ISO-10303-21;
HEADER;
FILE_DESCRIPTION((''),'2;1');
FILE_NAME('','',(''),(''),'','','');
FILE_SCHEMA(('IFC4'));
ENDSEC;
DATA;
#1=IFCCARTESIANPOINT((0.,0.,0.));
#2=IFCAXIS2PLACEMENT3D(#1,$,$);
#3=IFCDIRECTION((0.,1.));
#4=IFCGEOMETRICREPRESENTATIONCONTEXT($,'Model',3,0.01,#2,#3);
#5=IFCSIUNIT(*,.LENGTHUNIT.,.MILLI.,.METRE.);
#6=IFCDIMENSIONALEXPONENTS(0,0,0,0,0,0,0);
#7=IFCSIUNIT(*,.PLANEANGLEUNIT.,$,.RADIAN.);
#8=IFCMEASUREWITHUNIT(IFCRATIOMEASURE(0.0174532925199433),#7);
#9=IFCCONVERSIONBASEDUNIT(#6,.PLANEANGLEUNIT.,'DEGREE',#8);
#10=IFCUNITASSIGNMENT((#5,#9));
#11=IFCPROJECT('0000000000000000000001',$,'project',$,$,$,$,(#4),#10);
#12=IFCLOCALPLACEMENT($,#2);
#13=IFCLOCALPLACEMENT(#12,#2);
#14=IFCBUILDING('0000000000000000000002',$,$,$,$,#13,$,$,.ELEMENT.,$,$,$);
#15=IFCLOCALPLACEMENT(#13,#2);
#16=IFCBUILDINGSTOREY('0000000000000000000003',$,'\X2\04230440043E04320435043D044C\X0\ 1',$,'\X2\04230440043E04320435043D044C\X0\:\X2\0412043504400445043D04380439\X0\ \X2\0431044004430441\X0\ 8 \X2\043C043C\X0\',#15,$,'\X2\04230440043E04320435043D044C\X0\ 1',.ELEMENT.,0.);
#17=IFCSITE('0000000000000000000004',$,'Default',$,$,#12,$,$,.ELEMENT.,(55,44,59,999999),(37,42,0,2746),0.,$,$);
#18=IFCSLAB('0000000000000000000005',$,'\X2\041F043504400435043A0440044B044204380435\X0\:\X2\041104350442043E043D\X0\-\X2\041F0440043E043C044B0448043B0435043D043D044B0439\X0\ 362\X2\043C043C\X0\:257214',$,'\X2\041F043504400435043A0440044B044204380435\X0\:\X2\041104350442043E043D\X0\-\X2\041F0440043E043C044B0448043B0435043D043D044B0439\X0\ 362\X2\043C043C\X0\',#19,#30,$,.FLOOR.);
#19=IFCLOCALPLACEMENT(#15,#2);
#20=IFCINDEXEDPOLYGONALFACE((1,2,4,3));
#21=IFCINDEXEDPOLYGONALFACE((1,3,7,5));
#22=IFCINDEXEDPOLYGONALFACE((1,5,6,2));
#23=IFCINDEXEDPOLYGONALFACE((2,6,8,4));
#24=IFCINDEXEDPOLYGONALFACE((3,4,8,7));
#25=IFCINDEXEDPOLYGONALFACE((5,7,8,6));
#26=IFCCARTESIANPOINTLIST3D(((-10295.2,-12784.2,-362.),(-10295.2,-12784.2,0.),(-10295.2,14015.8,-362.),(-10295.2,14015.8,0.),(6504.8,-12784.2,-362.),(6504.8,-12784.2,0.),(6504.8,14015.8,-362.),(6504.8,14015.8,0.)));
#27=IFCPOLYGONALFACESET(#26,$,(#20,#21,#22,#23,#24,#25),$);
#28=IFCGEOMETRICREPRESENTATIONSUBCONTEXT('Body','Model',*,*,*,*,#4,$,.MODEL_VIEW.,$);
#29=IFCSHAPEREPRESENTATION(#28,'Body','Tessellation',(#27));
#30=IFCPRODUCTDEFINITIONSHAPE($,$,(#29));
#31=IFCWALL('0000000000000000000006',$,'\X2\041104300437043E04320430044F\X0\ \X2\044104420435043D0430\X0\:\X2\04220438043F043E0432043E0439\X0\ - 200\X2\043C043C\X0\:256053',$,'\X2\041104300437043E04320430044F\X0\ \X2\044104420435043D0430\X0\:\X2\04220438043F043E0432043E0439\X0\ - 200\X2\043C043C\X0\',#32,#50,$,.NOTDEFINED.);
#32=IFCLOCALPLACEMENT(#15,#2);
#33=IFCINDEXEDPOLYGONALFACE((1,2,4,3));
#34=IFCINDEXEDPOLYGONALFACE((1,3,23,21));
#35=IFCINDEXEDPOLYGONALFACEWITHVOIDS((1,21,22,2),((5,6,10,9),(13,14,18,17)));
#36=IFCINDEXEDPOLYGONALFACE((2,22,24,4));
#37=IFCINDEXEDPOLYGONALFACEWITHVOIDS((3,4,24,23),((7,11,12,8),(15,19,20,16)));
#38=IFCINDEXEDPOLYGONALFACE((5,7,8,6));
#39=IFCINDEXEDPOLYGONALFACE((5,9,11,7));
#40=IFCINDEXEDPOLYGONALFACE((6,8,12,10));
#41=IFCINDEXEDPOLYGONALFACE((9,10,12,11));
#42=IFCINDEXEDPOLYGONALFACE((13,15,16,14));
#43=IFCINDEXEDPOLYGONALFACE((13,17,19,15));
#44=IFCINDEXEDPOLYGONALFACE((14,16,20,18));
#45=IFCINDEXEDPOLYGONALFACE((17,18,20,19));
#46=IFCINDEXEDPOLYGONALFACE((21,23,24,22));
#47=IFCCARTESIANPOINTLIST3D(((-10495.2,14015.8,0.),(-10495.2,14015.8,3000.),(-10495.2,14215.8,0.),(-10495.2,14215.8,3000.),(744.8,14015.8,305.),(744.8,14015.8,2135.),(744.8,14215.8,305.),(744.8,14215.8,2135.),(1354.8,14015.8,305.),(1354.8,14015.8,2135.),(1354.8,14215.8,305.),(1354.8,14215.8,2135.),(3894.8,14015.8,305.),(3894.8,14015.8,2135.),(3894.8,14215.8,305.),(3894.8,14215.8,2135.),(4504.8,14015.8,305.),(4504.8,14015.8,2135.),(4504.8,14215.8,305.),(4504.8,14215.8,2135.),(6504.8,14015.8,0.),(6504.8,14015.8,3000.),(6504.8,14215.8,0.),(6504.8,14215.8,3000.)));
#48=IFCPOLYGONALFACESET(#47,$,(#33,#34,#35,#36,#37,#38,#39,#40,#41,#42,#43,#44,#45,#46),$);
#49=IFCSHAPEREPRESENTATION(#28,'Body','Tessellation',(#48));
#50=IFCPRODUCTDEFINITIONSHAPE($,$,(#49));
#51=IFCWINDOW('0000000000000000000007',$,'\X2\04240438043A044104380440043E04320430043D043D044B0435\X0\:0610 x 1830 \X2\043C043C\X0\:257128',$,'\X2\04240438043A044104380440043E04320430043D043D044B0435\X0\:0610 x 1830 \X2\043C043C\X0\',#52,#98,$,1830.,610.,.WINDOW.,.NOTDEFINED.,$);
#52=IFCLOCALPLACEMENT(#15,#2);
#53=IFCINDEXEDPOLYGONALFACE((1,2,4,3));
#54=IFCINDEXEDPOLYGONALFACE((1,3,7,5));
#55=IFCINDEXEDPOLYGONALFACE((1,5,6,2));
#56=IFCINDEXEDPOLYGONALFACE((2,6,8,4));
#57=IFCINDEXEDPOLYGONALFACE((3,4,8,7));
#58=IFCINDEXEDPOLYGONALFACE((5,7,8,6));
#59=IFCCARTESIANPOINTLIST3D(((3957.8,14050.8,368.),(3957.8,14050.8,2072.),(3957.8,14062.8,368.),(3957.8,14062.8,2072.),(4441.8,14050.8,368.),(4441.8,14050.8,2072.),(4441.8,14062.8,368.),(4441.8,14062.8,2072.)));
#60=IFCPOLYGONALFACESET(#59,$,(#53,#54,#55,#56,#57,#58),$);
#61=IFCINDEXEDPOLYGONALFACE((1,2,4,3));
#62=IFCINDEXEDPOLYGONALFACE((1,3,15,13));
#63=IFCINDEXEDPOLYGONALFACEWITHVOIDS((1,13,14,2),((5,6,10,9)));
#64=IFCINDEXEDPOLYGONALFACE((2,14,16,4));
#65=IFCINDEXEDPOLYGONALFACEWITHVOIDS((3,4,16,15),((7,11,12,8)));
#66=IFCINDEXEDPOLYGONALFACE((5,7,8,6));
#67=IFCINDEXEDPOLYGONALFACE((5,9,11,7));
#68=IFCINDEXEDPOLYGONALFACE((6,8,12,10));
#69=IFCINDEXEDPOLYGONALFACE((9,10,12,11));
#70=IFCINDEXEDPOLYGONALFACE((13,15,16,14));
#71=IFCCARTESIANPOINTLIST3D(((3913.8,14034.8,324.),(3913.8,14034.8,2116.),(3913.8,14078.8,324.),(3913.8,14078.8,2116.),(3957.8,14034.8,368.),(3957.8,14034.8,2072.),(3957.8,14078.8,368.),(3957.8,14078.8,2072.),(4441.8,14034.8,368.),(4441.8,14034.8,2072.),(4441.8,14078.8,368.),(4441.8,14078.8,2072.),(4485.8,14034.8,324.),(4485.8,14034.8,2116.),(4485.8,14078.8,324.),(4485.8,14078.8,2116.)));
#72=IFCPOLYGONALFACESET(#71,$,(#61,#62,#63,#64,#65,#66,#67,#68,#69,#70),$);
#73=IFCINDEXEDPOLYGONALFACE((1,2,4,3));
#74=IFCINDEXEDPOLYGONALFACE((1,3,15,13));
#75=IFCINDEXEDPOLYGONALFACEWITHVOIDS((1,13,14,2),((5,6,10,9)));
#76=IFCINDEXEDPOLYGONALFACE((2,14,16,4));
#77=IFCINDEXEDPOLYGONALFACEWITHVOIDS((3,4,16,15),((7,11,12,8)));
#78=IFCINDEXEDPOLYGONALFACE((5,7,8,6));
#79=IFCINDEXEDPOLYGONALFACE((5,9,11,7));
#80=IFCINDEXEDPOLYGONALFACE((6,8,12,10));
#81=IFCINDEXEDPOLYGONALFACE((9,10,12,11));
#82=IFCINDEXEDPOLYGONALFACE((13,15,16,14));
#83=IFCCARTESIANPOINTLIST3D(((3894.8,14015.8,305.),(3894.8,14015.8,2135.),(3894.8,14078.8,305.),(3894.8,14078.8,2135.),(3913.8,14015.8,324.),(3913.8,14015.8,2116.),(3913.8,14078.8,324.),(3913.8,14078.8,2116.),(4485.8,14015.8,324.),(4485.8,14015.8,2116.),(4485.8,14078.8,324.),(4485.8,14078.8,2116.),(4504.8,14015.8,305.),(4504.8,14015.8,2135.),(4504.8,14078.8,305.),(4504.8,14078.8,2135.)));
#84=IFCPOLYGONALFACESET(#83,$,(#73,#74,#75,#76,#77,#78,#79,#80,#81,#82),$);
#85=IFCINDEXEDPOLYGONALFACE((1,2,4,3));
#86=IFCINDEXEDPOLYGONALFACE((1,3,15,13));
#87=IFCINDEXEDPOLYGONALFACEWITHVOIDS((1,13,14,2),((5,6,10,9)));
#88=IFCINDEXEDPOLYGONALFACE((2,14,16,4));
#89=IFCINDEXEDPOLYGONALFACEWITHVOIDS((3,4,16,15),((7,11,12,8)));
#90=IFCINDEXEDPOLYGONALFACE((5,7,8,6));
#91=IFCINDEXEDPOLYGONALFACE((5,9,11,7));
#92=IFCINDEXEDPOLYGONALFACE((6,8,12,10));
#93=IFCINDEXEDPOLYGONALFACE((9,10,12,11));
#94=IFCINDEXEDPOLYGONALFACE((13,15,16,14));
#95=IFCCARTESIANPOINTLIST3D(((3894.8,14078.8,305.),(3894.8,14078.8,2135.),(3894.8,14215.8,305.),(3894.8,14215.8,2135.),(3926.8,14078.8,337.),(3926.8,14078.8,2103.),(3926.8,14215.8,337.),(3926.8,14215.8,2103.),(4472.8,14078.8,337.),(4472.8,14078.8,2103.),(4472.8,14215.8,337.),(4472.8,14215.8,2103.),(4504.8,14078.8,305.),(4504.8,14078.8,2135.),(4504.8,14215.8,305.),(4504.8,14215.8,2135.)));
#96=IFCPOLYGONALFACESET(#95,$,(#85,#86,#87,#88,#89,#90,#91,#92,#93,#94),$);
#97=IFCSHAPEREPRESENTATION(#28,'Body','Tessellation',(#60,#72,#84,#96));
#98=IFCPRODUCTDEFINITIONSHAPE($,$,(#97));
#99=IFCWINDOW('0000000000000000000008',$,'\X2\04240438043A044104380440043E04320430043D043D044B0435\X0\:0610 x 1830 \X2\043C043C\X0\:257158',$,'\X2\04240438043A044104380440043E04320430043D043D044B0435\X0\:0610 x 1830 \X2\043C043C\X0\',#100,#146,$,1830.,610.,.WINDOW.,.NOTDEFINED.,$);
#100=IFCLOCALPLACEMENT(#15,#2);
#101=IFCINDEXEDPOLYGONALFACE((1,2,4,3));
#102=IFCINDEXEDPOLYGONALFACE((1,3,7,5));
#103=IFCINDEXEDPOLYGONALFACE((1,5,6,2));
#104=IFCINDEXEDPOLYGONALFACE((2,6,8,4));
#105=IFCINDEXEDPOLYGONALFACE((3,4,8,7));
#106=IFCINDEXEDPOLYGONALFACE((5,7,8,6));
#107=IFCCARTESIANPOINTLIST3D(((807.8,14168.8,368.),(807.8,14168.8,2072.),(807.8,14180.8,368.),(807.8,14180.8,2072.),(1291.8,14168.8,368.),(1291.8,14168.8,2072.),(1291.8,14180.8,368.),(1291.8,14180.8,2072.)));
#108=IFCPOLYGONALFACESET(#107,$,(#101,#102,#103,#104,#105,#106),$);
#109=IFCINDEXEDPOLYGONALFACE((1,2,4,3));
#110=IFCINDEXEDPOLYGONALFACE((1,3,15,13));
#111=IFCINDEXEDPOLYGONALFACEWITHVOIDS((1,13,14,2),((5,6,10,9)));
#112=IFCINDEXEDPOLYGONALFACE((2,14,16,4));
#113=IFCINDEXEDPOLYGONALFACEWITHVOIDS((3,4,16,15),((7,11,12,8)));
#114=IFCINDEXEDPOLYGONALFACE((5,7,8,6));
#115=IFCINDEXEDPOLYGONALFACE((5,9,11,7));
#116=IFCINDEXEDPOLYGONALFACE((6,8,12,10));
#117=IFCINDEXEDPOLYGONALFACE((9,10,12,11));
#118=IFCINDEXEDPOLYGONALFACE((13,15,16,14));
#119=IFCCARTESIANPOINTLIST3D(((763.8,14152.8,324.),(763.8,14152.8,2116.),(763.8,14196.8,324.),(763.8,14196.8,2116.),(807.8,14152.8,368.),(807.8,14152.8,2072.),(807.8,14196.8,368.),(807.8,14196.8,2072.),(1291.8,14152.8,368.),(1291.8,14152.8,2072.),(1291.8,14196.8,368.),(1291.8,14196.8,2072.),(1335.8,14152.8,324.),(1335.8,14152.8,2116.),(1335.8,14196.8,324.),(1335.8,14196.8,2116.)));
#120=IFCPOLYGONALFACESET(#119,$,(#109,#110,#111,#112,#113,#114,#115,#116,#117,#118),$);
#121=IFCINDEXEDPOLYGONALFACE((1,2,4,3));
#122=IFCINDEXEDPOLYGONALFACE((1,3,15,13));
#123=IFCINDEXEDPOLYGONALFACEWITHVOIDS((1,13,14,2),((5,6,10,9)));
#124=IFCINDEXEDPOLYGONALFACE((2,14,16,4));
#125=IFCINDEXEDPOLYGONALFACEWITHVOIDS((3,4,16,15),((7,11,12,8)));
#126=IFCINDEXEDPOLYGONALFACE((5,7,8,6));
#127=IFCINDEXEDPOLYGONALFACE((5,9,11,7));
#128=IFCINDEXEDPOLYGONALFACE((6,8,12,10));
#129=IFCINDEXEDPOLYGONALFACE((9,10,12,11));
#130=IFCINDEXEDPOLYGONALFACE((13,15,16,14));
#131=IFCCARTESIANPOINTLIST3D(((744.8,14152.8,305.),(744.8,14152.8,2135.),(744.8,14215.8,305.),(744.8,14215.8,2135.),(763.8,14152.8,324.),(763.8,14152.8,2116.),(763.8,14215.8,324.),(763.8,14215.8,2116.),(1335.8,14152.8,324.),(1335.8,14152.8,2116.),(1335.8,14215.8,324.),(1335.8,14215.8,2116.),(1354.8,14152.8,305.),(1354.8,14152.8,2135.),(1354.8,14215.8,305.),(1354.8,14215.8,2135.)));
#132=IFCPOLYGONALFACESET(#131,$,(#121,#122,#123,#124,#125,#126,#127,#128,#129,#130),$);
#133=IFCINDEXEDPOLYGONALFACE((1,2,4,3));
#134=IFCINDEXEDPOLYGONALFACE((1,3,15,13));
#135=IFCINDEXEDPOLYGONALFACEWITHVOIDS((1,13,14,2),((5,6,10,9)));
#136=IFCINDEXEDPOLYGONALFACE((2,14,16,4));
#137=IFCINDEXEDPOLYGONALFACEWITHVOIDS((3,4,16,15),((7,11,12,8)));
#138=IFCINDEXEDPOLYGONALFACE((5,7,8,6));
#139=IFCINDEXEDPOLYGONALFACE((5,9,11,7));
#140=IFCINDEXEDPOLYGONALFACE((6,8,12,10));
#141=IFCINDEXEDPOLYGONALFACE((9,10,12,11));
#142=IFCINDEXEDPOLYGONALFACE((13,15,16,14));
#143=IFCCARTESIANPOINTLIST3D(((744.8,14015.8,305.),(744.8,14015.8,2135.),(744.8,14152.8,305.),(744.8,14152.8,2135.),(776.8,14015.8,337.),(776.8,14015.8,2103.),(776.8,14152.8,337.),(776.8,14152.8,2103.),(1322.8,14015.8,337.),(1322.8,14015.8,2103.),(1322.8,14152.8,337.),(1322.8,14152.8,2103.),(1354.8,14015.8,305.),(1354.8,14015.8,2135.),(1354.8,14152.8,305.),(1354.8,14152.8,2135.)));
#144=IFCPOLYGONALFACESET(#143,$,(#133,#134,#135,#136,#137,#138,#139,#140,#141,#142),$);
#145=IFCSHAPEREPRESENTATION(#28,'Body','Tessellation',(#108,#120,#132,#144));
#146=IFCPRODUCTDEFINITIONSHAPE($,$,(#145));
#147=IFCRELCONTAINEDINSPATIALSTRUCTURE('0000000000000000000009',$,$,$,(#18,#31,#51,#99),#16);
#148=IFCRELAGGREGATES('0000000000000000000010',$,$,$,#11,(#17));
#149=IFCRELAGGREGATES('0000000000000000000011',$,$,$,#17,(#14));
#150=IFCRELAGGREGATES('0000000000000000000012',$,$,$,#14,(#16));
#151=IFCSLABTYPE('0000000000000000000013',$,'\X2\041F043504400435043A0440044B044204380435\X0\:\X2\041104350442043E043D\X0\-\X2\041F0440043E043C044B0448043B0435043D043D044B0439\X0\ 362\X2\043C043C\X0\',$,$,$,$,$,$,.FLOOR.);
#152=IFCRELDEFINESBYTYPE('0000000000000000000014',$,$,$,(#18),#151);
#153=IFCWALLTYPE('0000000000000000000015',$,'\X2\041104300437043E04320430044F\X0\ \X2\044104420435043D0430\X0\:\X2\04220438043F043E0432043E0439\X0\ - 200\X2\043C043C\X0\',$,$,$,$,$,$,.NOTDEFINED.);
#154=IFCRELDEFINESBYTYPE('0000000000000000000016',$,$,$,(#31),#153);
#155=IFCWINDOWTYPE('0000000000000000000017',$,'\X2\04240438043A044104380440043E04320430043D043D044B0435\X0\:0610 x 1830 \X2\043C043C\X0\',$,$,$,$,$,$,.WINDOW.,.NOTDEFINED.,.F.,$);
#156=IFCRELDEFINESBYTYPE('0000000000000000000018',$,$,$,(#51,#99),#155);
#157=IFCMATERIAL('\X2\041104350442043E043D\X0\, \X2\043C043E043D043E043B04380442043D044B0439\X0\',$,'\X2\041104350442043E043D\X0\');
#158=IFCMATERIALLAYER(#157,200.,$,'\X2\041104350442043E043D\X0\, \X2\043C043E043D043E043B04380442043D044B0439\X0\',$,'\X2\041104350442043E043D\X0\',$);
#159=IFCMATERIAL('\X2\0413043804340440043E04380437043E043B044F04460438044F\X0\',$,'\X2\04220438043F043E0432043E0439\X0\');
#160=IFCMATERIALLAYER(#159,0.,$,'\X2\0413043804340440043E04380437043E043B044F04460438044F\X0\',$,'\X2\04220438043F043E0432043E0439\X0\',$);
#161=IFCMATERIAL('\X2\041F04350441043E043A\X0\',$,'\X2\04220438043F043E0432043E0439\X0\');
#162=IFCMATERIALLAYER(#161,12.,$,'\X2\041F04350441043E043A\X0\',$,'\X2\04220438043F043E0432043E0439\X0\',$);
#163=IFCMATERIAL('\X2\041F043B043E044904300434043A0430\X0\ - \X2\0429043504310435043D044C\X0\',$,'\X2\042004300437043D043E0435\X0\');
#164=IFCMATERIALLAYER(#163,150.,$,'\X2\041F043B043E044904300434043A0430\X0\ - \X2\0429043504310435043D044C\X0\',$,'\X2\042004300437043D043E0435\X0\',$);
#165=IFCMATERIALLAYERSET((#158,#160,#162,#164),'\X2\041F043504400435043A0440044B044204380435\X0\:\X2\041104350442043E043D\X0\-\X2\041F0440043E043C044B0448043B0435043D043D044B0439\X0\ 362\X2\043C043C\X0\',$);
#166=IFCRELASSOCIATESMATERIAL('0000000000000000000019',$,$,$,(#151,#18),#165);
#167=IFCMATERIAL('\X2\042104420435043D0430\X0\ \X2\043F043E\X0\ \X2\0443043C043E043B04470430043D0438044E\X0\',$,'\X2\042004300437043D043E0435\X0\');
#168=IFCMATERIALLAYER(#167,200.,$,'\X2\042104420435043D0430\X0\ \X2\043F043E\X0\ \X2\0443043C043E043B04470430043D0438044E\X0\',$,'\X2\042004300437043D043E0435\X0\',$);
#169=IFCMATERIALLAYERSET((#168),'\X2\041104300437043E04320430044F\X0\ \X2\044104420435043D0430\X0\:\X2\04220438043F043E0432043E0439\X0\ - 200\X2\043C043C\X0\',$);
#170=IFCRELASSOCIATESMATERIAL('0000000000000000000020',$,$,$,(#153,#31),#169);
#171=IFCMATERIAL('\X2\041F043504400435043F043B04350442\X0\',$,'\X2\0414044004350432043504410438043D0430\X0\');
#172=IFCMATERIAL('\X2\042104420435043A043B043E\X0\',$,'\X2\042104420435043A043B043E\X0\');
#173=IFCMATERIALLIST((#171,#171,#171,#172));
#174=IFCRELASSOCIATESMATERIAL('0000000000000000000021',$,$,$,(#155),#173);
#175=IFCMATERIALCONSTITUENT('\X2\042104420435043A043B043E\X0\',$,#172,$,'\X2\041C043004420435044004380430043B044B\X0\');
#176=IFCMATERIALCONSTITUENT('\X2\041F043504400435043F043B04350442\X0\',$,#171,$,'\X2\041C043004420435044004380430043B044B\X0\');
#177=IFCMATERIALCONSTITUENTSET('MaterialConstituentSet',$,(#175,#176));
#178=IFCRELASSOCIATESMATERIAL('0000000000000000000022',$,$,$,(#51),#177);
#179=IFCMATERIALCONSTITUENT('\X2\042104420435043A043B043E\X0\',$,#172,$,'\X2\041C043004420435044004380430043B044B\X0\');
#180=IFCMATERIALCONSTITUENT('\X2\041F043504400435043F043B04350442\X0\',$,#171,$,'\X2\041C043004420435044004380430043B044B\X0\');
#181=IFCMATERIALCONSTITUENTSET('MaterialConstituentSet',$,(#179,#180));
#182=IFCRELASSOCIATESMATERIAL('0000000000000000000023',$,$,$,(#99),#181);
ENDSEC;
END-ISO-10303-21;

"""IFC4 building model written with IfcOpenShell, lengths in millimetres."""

from ifc_helpers import new_model, entity, si_unit, converted_unit, direction, frame, frame_2d, origin, place, context, subcontext, project, spatial, polyline, rectangle, outline, extrude, source, transform, mapped, material, material_list, layer, layer_set, layer_usage, constituent, constituent_set, type_object, type_shapes, element, fill, save


model = new_model("IFC4")

# Units and contexts
model_context = context("Model", 3, precision=0.01, world=origin(), true_north=direction((0.0, 1.0)))
body_context = subcontext(model_context, "Body", "Model", "MODEL_VIEW")
ifc_project = project(units=[si_unit("LENGTHUNIT", "METRE", prefix="MILLI"), converted_unit("PLANEANGLEUNIT", "DEGREE", entity("IfcRatioMeasure", 0.0174532925199433), si_unit("PLANEANGLEUNIT", "RADIAN"), dimensions=[0, 0, 0, 0, 0, 0, 0])], contexts=[model_context])

# Site, building, storey
site_placement = place(None, origin())
site = spatial("IfcSite", under=ifc_project, at=site_placement, Name="Default", CompositionType="ELEMENT", RefLatitude=(55, 44, 59, 999999), RefLongitude=(37, 42, 0, 2746), RefElevation=0.0)
building_placement = place(site_placement, origin())
building = spatial("IfcBuilding", under=site, at=building_placement, CompositionType="ELEMENT")
storey_placement = place(building_placement, origin())
storey = spatial("IfcBuildingStorey", under=building, at=storey_placement, Name="Уровень 1", ObjectType="Уровень:Верхний брус 8 мм", LongName="Уровень 1", CompositionType="ELEMENT", Elevation=0.0)

# Slab
ifc_material_1 = material(Name="Бетон, монолитный", Category="Бетон")
ifc_layer_1 = layer(ifc_material_1, 200.0, Name="Бетон, монолитный", Category="Бетон")
ifc_material_2 = material(Name="Гидроизоляция", Category="Типовой")
ifc_layer_2 = layer(ifc_material_2, 0.0, Name="Гидроизоляция", Category="Типовой")
ifc_material_3 = material(Name="Песок", Category="Типовой")
ifc_layer_3 = layer(ifc_material_3, 12.0, Name="Песок", Category="Типовой")
ifc_material_4 = material(Name="Площадка - Щебень", Category="Разное")
ifc_layer_4 = layer(ifc_material_4, 150.0, Name="Площадка - Щебень", Category="Разное")
ifc_layer_set_1 = layer_set([ifc_layer_1, ifc_layer_2, ifc_layer_3, ifc_layer_4], Name="Перекрытие:Бетон-Промышленный 362мм")
ifc_layer_usage_1 = layer_usage(ifc_layer_set_1, "AXIS3", "POSITIVE", 0.0)
slab_type = type_object("IfcSlabType", Name="Перекрытие:Бетон-Промышленный 362мм", PredefinedType="FLOOR", material=ifc_layer_set_1)
slab_placement = place(storey_placement, origin())
element("IfcSlab", 1, at=slab_placement, inside=storey, type_object=slab_type, material=ifc_layer_usage_1, Name="Перекрытие:Бетон-Промышленный 362мм:257214", ObjectType="Перекрытие:Бетон-Промышленный 362мм", PredefinedType="FLOOR", context=body_context, shape_type="SweptSolid", body=[
    extrude(rectangle(XDim=26800.0, YDim=16800.0, at=frame_2d((0.0, 0.0), x_axis=(1.0, 0.0))), frame((-1895.2, 615.8, 0.0), z_axis=(0.0, 0.0, -1.0), x_axis=(0.0, 1.0, 0.0)), (0.0, 0.0, 1.0), 362.0),
])

# Wall, openings, windows
ifc_material_5 = material(Name="Стена по умолчанию", Category="Разное")
ifc_layer_5 = layer(ifc_material_5, 200.0, Name="Стена по умолчанию", Category="Разное")
ifc_layer_set_2 = layer_set([ifc_layer_5], Name="Базовая стена:Типовой - 200мм")
ifc_layer_usage_2 = layer_usage(ifc_layer_set_2, "AXIS2", "NEGATIVE", 100.0)
wall_type = type_object("IfcWallType", Name="Базовая стена:Типовой - 200мм", PredefinedType="NOTDEFINED", material=ifc_layer_set_2)
wall_1_placement = place(storey_placement, frame((-10495.2, 14115.8, 0.0)))
wall_1 = element("IfcWall", 2, at=wall_1_placement, inside=storey, type_object=wall_type, material=ifc_layer_usage_2, Name="Базовая стена:Типовой - 200мм:256053", ObjectType="Базовая стена:Типовой - 200мм", PredefinedType="NOTDEFINED", context=body_context, shape_type="SweptSolid", body=[
    extrude(rectangle(XDim=17000.0, YDim=200.0, at=frame_2d((8500.0, 0.0), x_axis=(-1.0, 0.0))), origin(), (0.0, 0.0, 1.0), 3000.0),
])
opening_1_placement = place(wall_1_placement, frame((15000.0, 100.0, 305.0)))
opening_1 = element("IfcOpeningElement", 3, at=opening_1_placement, cuts=wall_1, ObjectType="Opening", PredefinedType="OPENING", context=body_context, shape_type="SweptSolid", body=[
    extrude(rectangle(XDim=1830.0, YDim=610.0, at=frame_2d((915.0, 305.0), x_axis=(1.0, 0.0))), frame((0.0, 0.0, 0.0), z_axis=(0.0, -1.0, 0.0), x_axis=(0.0, 0.0, 1.0)), (0.0, 0.0, 1.0), 200.0),
])
opening_2_placement = place(wall_1_placement, frame((11240.0, -100.0, 305.0)))
opening_2 = element("IfcOpeningElement", 4, at=opening_2_placement, cuts=wall_1, ObjectType="Opening", PredefinedType="OPENING", context=body_context, shape_type="SweptSolid", body=[
    extrude(rectangle(XDim=1830.0, YDim=610.0, at=frame_2d((915.0, 305.0), x_axis=(1.0, 0.0))), frame((0.0, 0.0, 0.0), z_axis=(0.0, 1.0, 0.0), x_axis=(0.0, 0.0, 1.0)), (0.0, 0.0, 1.0), 200.0),
])
ifc_material_6 = material(Name="Стекло", Category="Стекло")
ifc_constituent_1 = constituent(ifc_material_6, Name="Стекло", Category="Материалы")
ifc_material_7 = material(Name="Переплет", Category="Древесина")
ifc_constituent_2 = constituent(ifc_material_7, Name="Переплет", Category="Материалы")
ifc_constituent_set_1 = constituent_set(constituents=[ifc_constituent_1, ifc_constituent_2], Name="MaterialConstituentSet")
ifc_material_list_1 = material_list([ifc_material_7, ifc_material_7, ifc_material_7, ifc_material_6])
window_type = type_object("IfcWindowType", Name="Фиксированные:0610 x 1830 мм", ParameterTakesPrecedence=False, PartitioningType="NOTDEFINED", PredefinedType="WINDOW", material=ifc_material_list_1)
shared_shape_1 = source(origin(), body_context, "Body", "SweptSolid", [
    extrude(rectangle(XDim=12.0, YDim=484.0, at=frame_2d((0.0, 0.0), x_axis=(1.0, 0.0))), frame((305.0, 159.0, 63.0), z_axis=(0.0, 0.0, 1.0), x_axis=(0.0, -1.0, 0.0)), (0.0, 0.0, 1.0), 1704.0),
    extrude(outline(polyline([(-286.0, -896.0), (286.0, -896.0), (286.0, 896.0), (-286.0, 896.0), (-286.0, -896.0)]), holes=[polyline([(-242.0, -852.0), (-242.0, 852.0), (242.0, 852.0), (242.0, -852.0), (-242.0, -852.0)])]), frame((305.0, 137.0, 915.0), z_axis=(0.0, 1.0, 0.0), x_axis=(1.0, 0.0, 0.0)), (0.0, 0.0, 1.0), 44.0),
    extrude(outline(polyline([(-305.0, -915.0), (305.0, -915.0), (305.0, 915.0), (-305.0, 915.0), (-305.0, -915.0)]), holes=[polyline([(-286.0, -896.0), (-286.0, 896.0), (286.0, 896.0), (286.0, -896.0), (-286.0, -896.0)])]), frame((305.0, 137.0, 915.0), z_axis=(0.0, 1.0, 0.0), x_axis=(1.0, 0.0, 0.0)), (0.0, 0.0, 1.0), 63.0),
    extrude(outline(polyline([(-305.0, -915.0), (305.0, -915.0), (305.0, 915.0), (-305.0, 915.0), (-305.0, -915.0)]), holes=[polyline([(-273.0, -883.0), (-273.0, 883.0), (273.0, 883.0), (273.0, -883.0), (-273.0, -883.0)])]), frame((305.0, 0.0, 915.0), z_axis=(0.0, 1.0, 0.0), x_axis=(1.0, 0.0, 0.0)), (0.0, 0.0, 1.0), 137.0),
])
type_shapes(window_type, [shared_shape_1])
window_1_placement = place(opening_1_placement, frame((0.0, 0.0, 0.0), z_axis=(0.0, 0.0, 1.0), x_axis=(-1.0, 0.0, 0.0)))
window_1 = element("IfcWindow", 5, at=window_1_placement, inside=storey, type_object=window_type, material=ifc_constituent_set_1, Name="Фиксированные:0610 x 1830 мм:257128", ObjectType="Фиксированные:0610 x 1830 мм", OverallHeight=1830.0, OverallWidth=610.0, PartitioningType="NOTDEFINED", PredefinedType="WINDOW", context=body_context, shape_type="MappedRepresentation", body=[
    mapped(shared_shape_1, transform((0.0, 0.0, 0.0), scale=1.0)),
])
fill(opening_1, window_1)
ifc_constituent_3 = constituent(ifc_material_6, Name="Стекло", Category="Материалы")
ifc_constituent_4 = constituent(ifc_material_7, Name="Переплет", Category="Материалы")
ifc_constituent_set_2 = constituent_set(constituents=[ifc_constituent_3, ifc_constituent_4], Name="MaterialConstituentSet")
window_2_placement = place(opening_2_placement, origin())
window_2 = element("IfcWindow", 6, at=window_2_placement, inside=storey, type_object=window_type, material=ifc_constituent_set_2, Name="Фиксированные:0610 x 1830 мм:257158", ObjectType="Фиксированные:0610 x 1830 мм", OverallHeight=1830.0, OverallWidth=610.0, PartitioningType="NOTDEFINED", PredefinedType="WINDOW", context=body_context, shape_type="MappedRepresentation", body=[
    mapped(shared_shape_1, transform((0.0, 0.0, 0.0), scale=1.0)),
])
fill(opening_2, window_2)

save(model, "model.ifc")
